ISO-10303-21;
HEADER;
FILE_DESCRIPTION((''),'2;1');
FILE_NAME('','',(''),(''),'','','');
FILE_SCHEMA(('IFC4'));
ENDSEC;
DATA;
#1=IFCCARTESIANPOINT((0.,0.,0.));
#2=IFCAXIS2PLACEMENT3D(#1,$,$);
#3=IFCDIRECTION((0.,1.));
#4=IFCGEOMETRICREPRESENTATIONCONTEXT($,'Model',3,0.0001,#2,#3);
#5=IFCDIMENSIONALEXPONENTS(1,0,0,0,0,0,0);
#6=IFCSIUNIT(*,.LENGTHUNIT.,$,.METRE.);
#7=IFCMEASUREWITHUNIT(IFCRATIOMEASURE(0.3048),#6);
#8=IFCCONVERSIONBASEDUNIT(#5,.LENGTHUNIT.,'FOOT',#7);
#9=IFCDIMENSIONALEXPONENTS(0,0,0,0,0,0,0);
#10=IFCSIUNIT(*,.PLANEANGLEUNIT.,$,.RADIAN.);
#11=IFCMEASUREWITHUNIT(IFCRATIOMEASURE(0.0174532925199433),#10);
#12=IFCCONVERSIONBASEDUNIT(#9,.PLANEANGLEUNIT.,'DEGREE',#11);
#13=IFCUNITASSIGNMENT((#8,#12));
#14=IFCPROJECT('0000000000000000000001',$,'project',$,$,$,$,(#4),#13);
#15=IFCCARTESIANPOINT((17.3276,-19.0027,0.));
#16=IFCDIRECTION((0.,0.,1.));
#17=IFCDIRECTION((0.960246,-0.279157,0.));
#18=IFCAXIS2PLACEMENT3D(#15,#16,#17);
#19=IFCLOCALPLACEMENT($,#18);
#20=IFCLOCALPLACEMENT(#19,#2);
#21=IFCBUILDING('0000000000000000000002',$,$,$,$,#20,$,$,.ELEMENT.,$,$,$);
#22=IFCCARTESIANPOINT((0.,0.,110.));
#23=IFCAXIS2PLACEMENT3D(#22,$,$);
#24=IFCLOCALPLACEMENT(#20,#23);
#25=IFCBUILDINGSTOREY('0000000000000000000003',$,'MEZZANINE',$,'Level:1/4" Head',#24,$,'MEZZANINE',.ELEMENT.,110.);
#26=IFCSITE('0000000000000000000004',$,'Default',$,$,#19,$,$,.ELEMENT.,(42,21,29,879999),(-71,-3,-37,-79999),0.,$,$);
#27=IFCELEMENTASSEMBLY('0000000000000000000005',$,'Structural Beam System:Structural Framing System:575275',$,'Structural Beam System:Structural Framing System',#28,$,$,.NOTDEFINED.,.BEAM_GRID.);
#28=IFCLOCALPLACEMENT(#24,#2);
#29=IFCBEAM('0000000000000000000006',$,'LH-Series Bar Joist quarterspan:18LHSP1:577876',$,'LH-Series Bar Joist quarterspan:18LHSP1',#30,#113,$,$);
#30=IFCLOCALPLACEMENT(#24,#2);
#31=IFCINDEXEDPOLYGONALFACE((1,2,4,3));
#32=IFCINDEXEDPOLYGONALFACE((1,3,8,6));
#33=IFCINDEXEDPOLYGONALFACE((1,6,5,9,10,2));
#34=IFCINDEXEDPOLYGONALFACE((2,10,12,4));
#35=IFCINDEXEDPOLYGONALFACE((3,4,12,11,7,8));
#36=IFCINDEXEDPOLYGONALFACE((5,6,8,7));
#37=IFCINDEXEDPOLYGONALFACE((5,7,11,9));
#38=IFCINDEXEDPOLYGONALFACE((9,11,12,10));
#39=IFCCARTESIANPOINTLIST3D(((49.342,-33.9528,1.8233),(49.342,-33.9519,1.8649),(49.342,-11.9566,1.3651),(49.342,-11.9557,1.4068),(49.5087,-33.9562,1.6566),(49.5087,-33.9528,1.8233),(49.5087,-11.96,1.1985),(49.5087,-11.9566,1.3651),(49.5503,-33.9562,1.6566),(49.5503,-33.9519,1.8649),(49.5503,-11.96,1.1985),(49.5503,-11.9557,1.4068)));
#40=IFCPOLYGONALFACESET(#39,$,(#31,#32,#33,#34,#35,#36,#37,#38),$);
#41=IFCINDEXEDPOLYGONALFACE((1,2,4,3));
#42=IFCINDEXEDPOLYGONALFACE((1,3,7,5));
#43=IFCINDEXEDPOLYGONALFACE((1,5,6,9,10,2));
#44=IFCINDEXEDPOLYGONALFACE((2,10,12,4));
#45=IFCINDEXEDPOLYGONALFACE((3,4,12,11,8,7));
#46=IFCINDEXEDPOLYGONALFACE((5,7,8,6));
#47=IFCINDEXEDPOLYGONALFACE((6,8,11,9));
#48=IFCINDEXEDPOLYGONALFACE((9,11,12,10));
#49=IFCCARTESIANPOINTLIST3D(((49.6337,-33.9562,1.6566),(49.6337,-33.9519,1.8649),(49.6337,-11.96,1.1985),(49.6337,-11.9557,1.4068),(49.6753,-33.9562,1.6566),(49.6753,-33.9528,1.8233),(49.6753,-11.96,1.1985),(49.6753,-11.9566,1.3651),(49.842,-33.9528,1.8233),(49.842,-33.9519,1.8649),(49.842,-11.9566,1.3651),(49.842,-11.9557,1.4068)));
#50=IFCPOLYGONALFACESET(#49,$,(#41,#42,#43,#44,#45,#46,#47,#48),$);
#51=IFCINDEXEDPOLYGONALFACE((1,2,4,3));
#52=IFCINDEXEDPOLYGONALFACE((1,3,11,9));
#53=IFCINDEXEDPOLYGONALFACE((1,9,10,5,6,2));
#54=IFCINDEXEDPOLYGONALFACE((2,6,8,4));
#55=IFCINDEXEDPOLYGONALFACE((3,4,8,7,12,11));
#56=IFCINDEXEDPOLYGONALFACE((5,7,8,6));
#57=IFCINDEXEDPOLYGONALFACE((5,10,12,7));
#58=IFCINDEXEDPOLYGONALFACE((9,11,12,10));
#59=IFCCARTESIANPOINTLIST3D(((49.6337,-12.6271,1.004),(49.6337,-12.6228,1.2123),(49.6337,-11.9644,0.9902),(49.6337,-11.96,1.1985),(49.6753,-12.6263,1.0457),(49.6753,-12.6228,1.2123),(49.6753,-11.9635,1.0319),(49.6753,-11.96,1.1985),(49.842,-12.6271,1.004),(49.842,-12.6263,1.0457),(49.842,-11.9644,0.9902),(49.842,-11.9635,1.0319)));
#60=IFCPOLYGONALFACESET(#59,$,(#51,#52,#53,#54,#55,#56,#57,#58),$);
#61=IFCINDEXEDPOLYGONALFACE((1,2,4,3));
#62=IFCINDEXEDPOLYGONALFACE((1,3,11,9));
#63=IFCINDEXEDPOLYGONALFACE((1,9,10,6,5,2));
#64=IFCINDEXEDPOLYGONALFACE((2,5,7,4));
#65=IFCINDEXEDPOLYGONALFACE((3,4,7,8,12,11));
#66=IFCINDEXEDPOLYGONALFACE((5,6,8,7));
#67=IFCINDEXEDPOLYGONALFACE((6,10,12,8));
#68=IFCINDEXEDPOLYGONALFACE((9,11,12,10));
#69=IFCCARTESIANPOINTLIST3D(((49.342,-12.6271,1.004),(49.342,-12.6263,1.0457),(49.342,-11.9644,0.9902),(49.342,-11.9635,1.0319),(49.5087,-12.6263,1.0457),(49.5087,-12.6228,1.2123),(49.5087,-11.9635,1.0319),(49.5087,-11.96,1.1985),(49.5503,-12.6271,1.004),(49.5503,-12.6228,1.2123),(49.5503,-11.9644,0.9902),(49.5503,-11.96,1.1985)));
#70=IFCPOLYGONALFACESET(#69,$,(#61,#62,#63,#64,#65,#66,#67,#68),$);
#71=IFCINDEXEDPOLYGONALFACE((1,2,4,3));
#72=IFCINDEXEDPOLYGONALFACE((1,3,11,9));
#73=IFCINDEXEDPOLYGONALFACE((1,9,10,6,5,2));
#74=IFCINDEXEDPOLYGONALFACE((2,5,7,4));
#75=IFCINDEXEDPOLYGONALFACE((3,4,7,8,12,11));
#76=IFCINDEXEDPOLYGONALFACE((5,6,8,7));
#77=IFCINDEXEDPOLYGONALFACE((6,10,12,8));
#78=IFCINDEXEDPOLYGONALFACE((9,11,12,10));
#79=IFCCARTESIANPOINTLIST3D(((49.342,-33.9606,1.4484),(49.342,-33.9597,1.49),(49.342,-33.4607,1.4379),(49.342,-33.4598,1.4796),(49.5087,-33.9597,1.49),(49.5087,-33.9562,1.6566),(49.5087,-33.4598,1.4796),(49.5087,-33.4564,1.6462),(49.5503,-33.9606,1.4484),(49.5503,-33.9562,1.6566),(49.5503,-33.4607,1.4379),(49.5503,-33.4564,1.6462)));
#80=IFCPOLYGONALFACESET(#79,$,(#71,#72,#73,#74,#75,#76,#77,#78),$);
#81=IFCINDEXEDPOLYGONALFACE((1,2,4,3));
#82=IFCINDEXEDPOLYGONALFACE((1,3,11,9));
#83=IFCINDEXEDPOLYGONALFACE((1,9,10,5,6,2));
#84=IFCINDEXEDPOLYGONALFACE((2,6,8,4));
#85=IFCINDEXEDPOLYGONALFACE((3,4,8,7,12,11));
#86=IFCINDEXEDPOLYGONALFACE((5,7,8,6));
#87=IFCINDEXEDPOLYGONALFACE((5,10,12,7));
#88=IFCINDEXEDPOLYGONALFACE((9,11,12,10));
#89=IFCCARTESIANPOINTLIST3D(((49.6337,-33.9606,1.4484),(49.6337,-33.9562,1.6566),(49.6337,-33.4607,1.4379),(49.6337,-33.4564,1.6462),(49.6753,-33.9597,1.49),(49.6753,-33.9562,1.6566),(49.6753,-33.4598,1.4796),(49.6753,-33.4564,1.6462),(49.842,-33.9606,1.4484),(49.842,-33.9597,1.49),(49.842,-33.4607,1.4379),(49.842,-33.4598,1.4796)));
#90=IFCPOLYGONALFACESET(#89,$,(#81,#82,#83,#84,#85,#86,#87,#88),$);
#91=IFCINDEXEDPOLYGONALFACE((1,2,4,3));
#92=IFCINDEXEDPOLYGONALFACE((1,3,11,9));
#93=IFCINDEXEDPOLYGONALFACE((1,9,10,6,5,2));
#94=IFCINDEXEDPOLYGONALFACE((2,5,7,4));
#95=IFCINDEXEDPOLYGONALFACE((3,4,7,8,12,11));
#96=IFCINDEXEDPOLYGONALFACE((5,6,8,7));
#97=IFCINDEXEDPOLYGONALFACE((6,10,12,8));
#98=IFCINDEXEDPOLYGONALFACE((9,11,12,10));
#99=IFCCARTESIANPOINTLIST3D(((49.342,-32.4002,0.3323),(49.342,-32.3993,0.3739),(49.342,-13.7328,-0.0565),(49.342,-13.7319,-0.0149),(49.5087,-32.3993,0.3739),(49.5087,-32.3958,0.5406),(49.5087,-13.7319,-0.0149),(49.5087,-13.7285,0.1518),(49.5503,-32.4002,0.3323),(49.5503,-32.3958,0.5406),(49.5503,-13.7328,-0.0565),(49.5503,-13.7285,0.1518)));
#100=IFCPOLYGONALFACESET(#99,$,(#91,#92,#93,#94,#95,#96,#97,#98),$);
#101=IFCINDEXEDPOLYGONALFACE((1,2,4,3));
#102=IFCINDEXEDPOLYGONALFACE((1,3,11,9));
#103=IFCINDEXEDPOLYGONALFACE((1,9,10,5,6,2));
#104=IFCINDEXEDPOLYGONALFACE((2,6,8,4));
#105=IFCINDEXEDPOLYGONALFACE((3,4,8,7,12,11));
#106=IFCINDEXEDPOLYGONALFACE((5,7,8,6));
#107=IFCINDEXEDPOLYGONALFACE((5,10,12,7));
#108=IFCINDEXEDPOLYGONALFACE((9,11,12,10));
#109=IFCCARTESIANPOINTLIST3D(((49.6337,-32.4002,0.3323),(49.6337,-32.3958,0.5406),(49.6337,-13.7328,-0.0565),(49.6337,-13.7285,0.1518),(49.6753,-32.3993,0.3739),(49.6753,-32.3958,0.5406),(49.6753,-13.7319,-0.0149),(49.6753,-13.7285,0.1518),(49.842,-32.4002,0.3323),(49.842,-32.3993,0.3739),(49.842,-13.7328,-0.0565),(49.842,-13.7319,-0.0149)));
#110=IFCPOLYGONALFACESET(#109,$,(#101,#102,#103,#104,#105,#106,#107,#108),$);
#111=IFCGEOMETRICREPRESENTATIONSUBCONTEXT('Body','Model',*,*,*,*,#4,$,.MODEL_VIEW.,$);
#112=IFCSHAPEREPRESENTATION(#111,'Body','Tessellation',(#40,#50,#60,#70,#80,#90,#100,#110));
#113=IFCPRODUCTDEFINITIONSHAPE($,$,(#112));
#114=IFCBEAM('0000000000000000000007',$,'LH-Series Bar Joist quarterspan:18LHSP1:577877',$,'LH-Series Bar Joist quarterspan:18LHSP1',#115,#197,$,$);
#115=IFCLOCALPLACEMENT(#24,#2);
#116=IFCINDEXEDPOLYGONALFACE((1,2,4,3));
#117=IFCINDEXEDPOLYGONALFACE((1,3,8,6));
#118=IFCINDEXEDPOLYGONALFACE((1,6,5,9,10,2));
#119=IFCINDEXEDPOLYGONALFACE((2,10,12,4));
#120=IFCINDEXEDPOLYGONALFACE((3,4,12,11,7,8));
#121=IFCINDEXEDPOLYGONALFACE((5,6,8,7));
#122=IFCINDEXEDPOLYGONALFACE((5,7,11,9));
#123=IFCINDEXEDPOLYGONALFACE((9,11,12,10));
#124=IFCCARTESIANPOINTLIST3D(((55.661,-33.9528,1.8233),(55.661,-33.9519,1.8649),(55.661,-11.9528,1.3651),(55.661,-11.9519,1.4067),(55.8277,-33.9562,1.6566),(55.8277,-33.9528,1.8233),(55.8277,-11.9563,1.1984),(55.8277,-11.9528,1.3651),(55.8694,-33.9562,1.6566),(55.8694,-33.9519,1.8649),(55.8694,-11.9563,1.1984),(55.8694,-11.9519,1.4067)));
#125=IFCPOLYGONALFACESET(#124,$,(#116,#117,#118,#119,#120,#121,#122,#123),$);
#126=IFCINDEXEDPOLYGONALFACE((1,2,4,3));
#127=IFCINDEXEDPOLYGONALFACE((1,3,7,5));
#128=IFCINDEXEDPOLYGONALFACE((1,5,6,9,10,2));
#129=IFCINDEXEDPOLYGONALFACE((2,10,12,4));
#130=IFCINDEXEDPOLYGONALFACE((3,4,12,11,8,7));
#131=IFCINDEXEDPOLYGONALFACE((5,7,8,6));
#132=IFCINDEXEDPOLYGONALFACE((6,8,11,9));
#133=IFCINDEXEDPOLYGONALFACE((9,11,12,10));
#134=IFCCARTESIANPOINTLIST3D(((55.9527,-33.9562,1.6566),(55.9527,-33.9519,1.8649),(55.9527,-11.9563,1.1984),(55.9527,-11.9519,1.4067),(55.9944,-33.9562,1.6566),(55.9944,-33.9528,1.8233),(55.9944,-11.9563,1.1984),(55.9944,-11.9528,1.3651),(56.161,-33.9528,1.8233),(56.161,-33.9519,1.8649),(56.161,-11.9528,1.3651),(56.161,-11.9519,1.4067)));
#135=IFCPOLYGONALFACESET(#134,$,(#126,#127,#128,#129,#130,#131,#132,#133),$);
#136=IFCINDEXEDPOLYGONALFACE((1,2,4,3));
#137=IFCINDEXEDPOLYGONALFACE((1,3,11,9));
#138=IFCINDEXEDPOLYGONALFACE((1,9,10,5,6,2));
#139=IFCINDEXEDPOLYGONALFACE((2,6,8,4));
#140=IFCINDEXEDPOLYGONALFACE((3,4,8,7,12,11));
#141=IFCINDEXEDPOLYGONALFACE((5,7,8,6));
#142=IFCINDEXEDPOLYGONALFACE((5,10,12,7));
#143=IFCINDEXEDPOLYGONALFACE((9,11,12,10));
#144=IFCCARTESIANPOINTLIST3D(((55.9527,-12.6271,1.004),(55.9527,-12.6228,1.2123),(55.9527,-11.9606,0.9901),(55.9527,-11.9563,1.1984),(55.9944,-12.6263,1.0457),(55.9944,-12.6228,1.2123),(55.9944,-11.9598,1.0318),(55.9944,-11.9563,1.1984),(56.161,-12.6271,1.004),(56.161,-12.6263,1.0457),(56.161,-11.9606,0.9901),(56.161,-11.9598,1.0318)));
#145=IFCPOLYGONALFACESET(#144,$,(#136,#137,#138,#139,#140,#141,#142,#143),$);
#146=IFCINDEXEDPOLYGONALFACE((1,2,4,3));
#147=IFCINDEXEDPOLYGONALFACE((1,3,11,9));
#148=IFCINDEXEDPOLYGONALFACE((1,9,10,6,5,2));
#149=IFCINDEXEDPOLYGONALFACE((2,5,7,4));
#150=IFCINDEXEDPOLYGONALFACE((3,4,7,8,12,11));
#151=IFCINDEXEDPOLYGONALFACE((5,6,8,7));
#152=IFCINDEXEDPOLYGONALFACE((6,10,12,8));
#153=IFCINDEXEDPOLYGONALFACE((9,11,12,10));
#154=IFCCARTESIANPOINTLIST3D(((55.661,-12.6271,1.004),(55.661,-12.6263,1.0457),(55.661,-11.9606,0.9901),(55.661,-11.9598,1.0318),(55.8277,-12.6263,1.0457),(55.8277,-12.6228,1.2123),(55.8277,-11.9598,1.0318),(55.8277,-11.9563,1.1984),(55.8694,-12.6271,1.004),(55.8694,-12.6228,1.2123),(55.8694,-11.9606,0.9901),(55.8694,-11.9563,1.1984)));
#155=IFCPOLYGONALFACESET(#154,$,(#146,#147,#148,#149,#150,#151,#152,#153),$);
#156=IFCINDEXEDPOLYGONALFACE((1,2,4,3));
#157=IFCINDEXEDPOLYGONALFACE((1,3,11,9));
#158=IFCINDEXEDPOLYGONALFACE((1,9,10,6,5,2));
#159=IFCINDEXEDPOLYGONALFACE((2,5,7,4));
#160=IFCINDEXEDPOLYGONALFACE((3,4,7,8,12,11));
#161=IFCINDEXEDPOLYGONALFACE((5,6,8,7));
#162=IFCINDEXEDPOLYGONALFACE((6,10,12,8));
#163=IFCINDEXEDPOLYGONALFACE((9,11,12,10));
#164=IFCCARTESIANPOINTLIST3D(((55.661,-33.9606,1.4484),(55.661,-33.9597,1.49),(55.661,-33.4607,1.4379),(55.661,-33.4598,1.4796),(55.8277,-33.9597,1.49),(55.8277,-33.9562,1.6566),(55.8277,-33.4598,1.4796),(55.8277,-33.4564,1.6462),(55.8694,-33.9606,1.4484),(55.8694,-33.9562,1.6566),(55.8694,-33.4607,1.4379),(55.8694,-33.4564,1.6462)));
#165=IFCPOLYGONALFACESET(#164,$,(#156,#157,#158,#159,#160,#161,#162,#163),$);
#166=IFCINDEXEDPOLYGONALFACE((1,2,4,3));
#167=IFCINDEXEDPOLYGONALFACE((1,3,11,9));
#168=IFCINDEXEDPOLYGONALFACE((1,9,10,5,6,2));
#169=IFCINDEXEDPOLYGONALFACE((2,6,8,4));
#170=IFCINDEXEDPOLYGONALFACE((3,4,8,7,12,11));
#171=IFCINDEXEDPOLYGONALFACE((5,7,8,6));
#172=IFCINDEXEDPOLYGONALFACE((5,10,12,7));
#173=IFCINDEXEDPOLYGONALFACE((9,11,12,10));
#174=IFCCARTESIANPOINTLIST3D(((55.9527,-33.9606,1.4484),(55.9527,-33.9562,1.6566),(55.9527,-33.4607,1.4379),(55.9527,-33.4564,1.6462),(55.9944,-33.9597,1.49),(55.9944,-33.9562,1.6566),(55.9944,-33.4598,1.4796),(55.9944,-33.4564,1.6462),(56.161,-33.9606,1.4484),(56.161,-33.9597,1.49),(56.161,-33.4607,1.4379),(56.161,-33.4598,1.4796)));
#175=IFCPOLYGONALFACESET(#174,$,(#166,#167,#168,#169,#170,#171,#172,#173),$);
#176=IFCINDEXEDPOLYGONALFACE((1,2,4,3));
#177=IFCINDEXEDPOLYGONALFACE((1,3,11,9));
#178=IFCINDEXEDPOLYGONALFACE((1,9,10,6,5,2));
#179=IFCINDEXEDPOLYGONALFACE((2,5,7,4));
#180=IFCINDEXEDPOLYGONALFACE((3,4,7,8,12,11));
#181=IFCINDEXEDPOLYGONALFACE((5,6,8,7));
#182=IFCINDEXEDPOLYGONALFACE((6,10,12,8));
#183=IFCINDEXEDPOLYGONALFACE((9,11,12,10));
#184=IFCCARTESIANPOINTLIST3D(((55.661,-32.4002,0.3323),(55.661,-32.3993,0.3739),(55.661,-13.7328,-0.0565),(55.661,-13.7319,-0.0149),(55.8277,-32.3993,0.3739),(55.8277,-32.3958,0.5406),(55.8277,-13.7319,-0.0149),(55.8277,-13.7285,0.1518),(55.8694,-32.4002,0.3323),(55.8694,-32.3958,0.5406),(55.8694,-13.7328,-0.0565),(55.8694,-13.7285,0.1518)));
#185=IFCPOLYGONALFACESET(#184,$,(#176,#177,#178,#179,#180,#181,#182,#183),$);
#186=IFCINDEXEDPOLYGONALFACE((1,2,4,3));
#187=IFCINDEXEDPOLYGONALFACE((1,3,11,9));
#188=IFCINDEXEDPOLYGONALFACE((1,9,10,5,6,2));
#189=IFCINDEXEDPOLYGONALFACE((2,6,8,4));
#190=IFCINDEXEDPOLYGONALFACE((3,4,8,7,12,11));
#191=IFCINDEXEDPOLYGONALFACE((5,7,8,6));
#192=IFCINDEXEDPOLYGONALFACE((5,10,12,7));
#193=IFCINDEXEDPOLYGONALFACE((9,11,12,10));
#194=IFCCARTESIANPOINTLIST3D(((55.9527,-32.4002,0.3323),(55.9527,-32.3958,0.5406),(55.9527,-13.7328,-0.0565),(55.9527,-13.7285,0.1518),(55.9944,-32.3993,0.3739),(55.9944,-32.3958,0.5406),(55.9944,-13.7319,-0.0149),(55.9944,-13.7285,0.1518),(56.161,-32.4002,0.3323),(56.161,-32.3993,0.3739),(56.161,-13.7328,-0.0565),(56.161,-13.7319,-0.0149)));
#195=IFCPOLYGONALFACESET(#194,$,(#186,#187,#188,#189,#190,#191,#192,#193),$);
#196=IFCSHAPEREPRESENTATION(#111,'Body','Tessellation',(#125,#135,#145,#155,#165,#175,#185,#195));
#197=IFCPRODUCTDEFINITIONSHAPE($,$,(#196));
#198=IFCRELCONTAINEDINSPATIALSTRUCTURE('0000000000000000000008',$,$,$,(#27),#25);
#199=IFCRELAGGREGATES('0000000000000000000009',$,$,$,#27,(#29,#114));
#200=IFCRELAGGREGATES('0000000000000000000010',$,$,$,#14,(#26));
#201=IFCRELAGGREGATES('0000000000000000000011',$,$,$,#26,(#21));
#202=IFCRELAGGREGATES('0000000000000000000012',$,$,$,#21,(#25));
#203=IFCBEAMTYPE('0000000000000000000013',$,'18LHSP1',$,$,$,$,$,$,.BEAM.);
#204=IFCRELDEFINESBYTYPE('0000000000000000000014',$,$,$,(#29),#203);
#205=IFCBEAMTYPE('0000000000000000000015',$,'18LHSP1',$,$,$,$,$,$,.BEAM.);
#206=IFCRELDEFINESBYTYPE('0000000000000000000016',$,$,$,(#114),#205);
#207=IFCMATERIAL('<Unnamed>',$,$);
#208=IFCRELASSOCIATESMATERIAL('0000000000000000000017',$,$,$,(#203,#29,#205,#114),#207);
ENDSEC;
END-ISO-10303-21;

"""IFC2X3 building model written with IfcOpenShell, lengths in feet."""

from ifc_helpers import new_model, entity, si_unit, converted_unit, direction, frame, origin, place, context, subcontext, project, spatial, polyline, outline, extrude, source, transform, mapped, material, type_object, type_shapes, element, aggregate, save


model = new_model("IFC2X3")

# Units and contexts
model_context = context("Model", 3, precision=0.0001, world=origin(), true_north=direction((0.0, 1.0)))
body_context = subcontext(model_context, "Body", "Model", "MODEL_VIEW")
ifc_project = project(units=[converted_unit("LENGTHUNIT", "FOOT", entity("IfcRatioMeasure", 0.3048), si_unit("LENGTHUNIT", "METRE"), dimensions=[1, 0, 0, 0, 0, 0, 0]), converted_unit("PLANEANGLEUNIT", "DEGREE", entity("IfcRatioMeasure", 0.0174532925199433), si_unit("PLANEANGLEUNIT", "RADIAN"), dimensions=[0, 0, 0, 0, 0, 0, 0])], contexts=[model_context])

# Site, building, storey
site_placement = place(None, frame((17.3276, -19.0027, 0.0), z_axis=(0.0, 0.0, 1.0), x_axis=(0.960246, -0.279157, 0.0)))
site = spatial("IfcSite", under=ifc_project, at=site_placement, Name="Default", CompositionType="ELEMENT", RefLatitude=(42, 21, 29, 879999), RefLongitude=(-71, -3, -37, -79999), RefElevation=0.0)
building_placement = place(site_placement, origin())
building = spatial("IfcBuilding", under=site, at=building_placement, CompositionType="ELEMENT")
storey_placement = place(building_placement, frame((0.0, 0.0, 110.0)))
storey = spatial("IfcBuildingStorey", under=building, at=storey_placement, Name="MEZZANINE", ObjectType="Level:1/4\" Head", LongName="MEZZANINE", CompositionType="ELEMENT", Elevation=110.0)

# Shared definitions
ifc_material_1 = material(Name="<Unnamed>")

# Element assembly, beams
assembly_1_placement = place(storey_placement, origin())
assembly_1 = element("IfcElementAssembly", 1, at=assembly_1_placement, inside=storey, Name="Structural Beam System:Structural Framing System:575275", ObjectType="Structural Beam System:Structural Framing System", AssemblyPlace="NOTDEFINED", PredefinedType="BEAM_GRID")
beam_type_1 = type_object("IfcBeamType", Name="18LHSP1", PredefinedType="BEAM", material=ifc_material_1)
shared_shape_1 = source(origin(), body_context, "Body", "SweptSolid", [
    extrude(outline(polyline([(-0.0833, -0.125), (-0.0417, -0.125), (-0.0417, 0.0417), (0.125, 0.0417), (0.125, 0.0833), (-0.0833, 0.0833), (-0.0833, -0.125)])), frame((-11.0819, -0.125, 0.6667), z_axis=(1.0, 0.0, 0.0), x_axis=(0.0, 0.0, -1.0)), (0.0, 0.0, 1.0), 22.001),
    extrude(outline(polyline([(-0.0833, -0.0833), (0.125, -0.0833), (0.125, -0.0417), (-0.0417, -0.0417), (-0.0417, 0.125), (-0.0833, 0.125), (-0.0833, -0.0833)])), frame((-11.0819, 0.125, 0.6667), z_axis=(1.0, 0.0, 0.0), x_axis=(0.0, 0.0, -1.0)), (0.0, 0.0, 1.0), 22.001),
    extrude(outline(polyline([(-0.125, -0.0833), (0.0833, -0.0833), (0.0833, 0.125), (0.0417, 0.125), (0.0417, -0.0417), (-0.125, -0.0417), (-0.125, -0.0833)])), frame((-11.0819, 0.125, 0.4167), z_axis=(1.0, 0.0, 0.0), x_axis=(0.0, 0.0, -1.0)), (0.0, 0.0, 1.0), 0.6629),
    extrude(outline(polyline([(0.0417, -0.125), (0.0833, -0.125), (0.0833, 0.0833), (-0.125, 0.0833), (-0.125, 0.0417), (0.0417, 0.0417), (0.0417, -0.125)])), frame((-11.0819, -0.125, 0.4167), z_axis=(1.0, 0.0, 0.0), x_axis=(0.0, 0.0, -1.0)), (0.0, 0.0, 1.0), 0.6629),
    extrude(outline(polyline([(0.0417, -0.125), (0.0833, -0.125), (0.0833, 0.0833), (-0.125, 0.0833), (-0.125, 0.0417), (0.0417, 0.0417), (0.0417, -0.125)])), frame((10.419, -0.125, 0.4167), z_axis=(1.0, 0.0, 0.0), x_axis=(0.0, 0.0, -1.0)), (0.0, 0.0, 1.0), 0.5),
    extrude(outline(polyline([(-0.125, -0.0833), (0.0833, -0.0833), (0.0833, 0.125), (0.0417, 0.125), (0.0417, -0.0417), (-0.125, -0.0417), (-0.125, -0.0833)])), frame((10.419, 0.125, 0.4167), z_axis=(1.0, 0.0, 0.0), x_axis=(0.0, 0.0, -1.0)), (0.0, 0.0, 1.0), 0.5),
    extrude(outline(polyline([(0.0417, -0.125), (0.0833, -0.125), (0.0833, 0.0833), (-0.125, 0.0833), (-0.125, 0.0417), (0.0417, 0.0417), (0.0417, -0.125)])), frame((-9.3357, -0.125, -0.6667), z_axis=(1.0, 0.0, 0.0), x_axis=(0.0, 0.0, -1.0)), (0.0, 0.0, 1.0), 18.6714),
    extrude(outline(polyline([(-0.125, -0.0833), (0.0833, -0.0833), (0.0833, 0.125), (0.0417, 0.125), (0.0417, -0.0417), (-0.125, -0.0417), (-0.125, -0.0833)])), frame((-9.3357, 0.125, -0.6667), z_axis=(1.0, 0.0, 0.0), x_axis=(0.0, 0.0, -1.0)), (0.0, 0.0, 1.0), 18.6714),
])
type_shapes(beam_type_1, [shared_shape_1])
beam_1_placement = place(assembly_1_placement, frame((49.592, -23.0509, 0.8877), z_axis=(0.0, 0.020824, 0.999783), x_axis=(0.0, -0.999783, 0.020824)))
beam_1 = element("IfcBeam", 2, at=beam_1_placement, type_object=beam_type_1, material=ifc_material_1, Name="LH-Series Bar Joist quarterspan:18LHSP1:577876", ObjectType="LH-Series Bar Joist quarterspan:18LHSP1", context=body_context, shape_type="MappedRepresentation", body=[
    mapped(shared_shape_1, transform((0.0, 0.0, 0.0), scale=1.0)),
])
beam_type_2 = type_object("IfcBeamType", Name="18LHSP1", PredefinedType="BEAM", material=ifc_material_1)
shared_shape_2 = source(origin(), body_context, "Body", "SweptSolid", [
    extrude(outline(polyline([(-0.0833, -0.125), (-0.0417, -0.125), (-0.0417, 0.0417), (0.125, 0.0417), (0.125, 0.0833), (-0.0833, 0.0833), (-0.0833, -0.125)])), frame((-11.0857, -0.125, 0.6667), z_axis=(1.0, 0.0, 0.0), x_axis=(0.0, 0.0, -1.0)), (0.0, 0.0, 1.0), 22.0047),
    extrude(outline(polyline([(-0.0833, -0.0833), (0.125, -0.0833), (0.125, -0.0417), (-0.0417, -0.0417), (-0.0417, 0.125), (-0.0833, 0.125), (-0.0833, -0.0833)])), frame((-11.0857, 0.125, 0.6667), z_axis=(1.0, 0.0, 0.0), x_axis=(0.0, 0.0, -1.0)), (0.0, 0.0, 1.0), 22.0047),
    extrude(outline(polyline([(-0.125, -0.0833), (0.0833, -0.0833), (0.0833, 0.125), (0.0417, 0.125), (0.0417, -0.0417), (-0.125, -0.0417), (-0.125, -0.0833)])), frame((-11.0857, 0.125, 0.4167), z_axis=(1.0, 0.0, 0.0), x_axis=(0.0, 0.0, -1.0)), (0.0, 0.0, 1.0), 0.6667),
    extrude(outline(polyline([(0.0417, -0.125), (0.0833, -0.125), (0.0833, 0.0833), (-0.125, 0.0833), (-0.125, 0.0417), (0.0417, 0.0417), (0.0417, -0.125)])), frame((-11.0857, -0.125, 0.4167), z_axis=(1.0, 0.0, 0.0), x_axis=(0.0, 0.0, -1.0)), (0.0, 0.0, 1.0), 0.6667),
    extrude(outline(polyline([(0.0417, -0.125), (0.0833, -0.125), (0.0833, 0.0833), (-0.125, 0.0833), (-0.125, 0.0417), (0.0417, 0.0417), (0.0417, -0.125)])), frame((10.419, -0.125, 0.4167), z_axis=(1.0, 0.0, 0.0), x_axis=(0.0, 0.0, -1.0)), (0.0, 0.0, 1.0), 0.5),
    extrude(outline(polyline([(-0.125, -0.0833), (0.0833, -0.0833), (0.0833, 0.125), (0.0417, 0.125), (0.0417, -0.0417), (-0.125, -0.0417), (-0.125, -0.0833)])), frame((10.419, 0.125, 0.4167), z_axis=(1.0, 0.0, 0.0), x_axis=(0.0, 0.0, -1.0)), (0.0, 0.0, 1.0), 0.5),
    extrude(outline(polyline([(0.0417, -0.125), (0.0833, -0.125), (0.0833, 0.0833), (-0.125, 0.0833), (-0.125, 0.0417), (0.0417, 0.0417), (0.0417, -0.125)])), frame((-9.3357, -0.125, -0.6667), z_axis=(1.0, 0.0, 0.0), x_axis=(0.0, 0.0, -1.0)), (0.0, 0.0, 1.0), 18.6714),
    extrude(outline(polyline([(-0.125, -0.0833), (0.0833, -0.0833), (0.0833, 0.125), (0.0417, 0.125), (0.0417, -0.0417), (-0.125, -0.0417), (-0.125, -0.0833)])), frame((-9.3357, 0.125, -0.6667), z_axis=(1.0, 0.0, 0.0), x_axis=(0.0, 0.0, -1.0)), (0.0, 0.0, 1.0), 18.6714),
])
type_shapes(beam_type_2, [shared_shape_2])
beam_2_placement = place(assembly_1_placement, frame((55.911, -23.0509, 0.8877), z_axis=(0.0, 0.020824, 0.999783), x_axis=(0.0, -0.999783, 0.020824)))
beam_2 = element("IfcBeam", 3, at=beam_2_placement, type_object=beam_type_2, material=ifc_material_1, Name="LH-Series Bar Joist quarterspan:18LHSP1:577877", ObjectType="LH-Series Bar Joist quarterspan:18LHSP1", context=body_context, shape_type="MappedRepresentation", body=[
    mapped(shared_shape_2, transform((0.0, 0.0, 0.0), scale=1.0)),
])
aggregate(assembly_1, [beam_1, beam_2])

save(model, "model.ifc")
